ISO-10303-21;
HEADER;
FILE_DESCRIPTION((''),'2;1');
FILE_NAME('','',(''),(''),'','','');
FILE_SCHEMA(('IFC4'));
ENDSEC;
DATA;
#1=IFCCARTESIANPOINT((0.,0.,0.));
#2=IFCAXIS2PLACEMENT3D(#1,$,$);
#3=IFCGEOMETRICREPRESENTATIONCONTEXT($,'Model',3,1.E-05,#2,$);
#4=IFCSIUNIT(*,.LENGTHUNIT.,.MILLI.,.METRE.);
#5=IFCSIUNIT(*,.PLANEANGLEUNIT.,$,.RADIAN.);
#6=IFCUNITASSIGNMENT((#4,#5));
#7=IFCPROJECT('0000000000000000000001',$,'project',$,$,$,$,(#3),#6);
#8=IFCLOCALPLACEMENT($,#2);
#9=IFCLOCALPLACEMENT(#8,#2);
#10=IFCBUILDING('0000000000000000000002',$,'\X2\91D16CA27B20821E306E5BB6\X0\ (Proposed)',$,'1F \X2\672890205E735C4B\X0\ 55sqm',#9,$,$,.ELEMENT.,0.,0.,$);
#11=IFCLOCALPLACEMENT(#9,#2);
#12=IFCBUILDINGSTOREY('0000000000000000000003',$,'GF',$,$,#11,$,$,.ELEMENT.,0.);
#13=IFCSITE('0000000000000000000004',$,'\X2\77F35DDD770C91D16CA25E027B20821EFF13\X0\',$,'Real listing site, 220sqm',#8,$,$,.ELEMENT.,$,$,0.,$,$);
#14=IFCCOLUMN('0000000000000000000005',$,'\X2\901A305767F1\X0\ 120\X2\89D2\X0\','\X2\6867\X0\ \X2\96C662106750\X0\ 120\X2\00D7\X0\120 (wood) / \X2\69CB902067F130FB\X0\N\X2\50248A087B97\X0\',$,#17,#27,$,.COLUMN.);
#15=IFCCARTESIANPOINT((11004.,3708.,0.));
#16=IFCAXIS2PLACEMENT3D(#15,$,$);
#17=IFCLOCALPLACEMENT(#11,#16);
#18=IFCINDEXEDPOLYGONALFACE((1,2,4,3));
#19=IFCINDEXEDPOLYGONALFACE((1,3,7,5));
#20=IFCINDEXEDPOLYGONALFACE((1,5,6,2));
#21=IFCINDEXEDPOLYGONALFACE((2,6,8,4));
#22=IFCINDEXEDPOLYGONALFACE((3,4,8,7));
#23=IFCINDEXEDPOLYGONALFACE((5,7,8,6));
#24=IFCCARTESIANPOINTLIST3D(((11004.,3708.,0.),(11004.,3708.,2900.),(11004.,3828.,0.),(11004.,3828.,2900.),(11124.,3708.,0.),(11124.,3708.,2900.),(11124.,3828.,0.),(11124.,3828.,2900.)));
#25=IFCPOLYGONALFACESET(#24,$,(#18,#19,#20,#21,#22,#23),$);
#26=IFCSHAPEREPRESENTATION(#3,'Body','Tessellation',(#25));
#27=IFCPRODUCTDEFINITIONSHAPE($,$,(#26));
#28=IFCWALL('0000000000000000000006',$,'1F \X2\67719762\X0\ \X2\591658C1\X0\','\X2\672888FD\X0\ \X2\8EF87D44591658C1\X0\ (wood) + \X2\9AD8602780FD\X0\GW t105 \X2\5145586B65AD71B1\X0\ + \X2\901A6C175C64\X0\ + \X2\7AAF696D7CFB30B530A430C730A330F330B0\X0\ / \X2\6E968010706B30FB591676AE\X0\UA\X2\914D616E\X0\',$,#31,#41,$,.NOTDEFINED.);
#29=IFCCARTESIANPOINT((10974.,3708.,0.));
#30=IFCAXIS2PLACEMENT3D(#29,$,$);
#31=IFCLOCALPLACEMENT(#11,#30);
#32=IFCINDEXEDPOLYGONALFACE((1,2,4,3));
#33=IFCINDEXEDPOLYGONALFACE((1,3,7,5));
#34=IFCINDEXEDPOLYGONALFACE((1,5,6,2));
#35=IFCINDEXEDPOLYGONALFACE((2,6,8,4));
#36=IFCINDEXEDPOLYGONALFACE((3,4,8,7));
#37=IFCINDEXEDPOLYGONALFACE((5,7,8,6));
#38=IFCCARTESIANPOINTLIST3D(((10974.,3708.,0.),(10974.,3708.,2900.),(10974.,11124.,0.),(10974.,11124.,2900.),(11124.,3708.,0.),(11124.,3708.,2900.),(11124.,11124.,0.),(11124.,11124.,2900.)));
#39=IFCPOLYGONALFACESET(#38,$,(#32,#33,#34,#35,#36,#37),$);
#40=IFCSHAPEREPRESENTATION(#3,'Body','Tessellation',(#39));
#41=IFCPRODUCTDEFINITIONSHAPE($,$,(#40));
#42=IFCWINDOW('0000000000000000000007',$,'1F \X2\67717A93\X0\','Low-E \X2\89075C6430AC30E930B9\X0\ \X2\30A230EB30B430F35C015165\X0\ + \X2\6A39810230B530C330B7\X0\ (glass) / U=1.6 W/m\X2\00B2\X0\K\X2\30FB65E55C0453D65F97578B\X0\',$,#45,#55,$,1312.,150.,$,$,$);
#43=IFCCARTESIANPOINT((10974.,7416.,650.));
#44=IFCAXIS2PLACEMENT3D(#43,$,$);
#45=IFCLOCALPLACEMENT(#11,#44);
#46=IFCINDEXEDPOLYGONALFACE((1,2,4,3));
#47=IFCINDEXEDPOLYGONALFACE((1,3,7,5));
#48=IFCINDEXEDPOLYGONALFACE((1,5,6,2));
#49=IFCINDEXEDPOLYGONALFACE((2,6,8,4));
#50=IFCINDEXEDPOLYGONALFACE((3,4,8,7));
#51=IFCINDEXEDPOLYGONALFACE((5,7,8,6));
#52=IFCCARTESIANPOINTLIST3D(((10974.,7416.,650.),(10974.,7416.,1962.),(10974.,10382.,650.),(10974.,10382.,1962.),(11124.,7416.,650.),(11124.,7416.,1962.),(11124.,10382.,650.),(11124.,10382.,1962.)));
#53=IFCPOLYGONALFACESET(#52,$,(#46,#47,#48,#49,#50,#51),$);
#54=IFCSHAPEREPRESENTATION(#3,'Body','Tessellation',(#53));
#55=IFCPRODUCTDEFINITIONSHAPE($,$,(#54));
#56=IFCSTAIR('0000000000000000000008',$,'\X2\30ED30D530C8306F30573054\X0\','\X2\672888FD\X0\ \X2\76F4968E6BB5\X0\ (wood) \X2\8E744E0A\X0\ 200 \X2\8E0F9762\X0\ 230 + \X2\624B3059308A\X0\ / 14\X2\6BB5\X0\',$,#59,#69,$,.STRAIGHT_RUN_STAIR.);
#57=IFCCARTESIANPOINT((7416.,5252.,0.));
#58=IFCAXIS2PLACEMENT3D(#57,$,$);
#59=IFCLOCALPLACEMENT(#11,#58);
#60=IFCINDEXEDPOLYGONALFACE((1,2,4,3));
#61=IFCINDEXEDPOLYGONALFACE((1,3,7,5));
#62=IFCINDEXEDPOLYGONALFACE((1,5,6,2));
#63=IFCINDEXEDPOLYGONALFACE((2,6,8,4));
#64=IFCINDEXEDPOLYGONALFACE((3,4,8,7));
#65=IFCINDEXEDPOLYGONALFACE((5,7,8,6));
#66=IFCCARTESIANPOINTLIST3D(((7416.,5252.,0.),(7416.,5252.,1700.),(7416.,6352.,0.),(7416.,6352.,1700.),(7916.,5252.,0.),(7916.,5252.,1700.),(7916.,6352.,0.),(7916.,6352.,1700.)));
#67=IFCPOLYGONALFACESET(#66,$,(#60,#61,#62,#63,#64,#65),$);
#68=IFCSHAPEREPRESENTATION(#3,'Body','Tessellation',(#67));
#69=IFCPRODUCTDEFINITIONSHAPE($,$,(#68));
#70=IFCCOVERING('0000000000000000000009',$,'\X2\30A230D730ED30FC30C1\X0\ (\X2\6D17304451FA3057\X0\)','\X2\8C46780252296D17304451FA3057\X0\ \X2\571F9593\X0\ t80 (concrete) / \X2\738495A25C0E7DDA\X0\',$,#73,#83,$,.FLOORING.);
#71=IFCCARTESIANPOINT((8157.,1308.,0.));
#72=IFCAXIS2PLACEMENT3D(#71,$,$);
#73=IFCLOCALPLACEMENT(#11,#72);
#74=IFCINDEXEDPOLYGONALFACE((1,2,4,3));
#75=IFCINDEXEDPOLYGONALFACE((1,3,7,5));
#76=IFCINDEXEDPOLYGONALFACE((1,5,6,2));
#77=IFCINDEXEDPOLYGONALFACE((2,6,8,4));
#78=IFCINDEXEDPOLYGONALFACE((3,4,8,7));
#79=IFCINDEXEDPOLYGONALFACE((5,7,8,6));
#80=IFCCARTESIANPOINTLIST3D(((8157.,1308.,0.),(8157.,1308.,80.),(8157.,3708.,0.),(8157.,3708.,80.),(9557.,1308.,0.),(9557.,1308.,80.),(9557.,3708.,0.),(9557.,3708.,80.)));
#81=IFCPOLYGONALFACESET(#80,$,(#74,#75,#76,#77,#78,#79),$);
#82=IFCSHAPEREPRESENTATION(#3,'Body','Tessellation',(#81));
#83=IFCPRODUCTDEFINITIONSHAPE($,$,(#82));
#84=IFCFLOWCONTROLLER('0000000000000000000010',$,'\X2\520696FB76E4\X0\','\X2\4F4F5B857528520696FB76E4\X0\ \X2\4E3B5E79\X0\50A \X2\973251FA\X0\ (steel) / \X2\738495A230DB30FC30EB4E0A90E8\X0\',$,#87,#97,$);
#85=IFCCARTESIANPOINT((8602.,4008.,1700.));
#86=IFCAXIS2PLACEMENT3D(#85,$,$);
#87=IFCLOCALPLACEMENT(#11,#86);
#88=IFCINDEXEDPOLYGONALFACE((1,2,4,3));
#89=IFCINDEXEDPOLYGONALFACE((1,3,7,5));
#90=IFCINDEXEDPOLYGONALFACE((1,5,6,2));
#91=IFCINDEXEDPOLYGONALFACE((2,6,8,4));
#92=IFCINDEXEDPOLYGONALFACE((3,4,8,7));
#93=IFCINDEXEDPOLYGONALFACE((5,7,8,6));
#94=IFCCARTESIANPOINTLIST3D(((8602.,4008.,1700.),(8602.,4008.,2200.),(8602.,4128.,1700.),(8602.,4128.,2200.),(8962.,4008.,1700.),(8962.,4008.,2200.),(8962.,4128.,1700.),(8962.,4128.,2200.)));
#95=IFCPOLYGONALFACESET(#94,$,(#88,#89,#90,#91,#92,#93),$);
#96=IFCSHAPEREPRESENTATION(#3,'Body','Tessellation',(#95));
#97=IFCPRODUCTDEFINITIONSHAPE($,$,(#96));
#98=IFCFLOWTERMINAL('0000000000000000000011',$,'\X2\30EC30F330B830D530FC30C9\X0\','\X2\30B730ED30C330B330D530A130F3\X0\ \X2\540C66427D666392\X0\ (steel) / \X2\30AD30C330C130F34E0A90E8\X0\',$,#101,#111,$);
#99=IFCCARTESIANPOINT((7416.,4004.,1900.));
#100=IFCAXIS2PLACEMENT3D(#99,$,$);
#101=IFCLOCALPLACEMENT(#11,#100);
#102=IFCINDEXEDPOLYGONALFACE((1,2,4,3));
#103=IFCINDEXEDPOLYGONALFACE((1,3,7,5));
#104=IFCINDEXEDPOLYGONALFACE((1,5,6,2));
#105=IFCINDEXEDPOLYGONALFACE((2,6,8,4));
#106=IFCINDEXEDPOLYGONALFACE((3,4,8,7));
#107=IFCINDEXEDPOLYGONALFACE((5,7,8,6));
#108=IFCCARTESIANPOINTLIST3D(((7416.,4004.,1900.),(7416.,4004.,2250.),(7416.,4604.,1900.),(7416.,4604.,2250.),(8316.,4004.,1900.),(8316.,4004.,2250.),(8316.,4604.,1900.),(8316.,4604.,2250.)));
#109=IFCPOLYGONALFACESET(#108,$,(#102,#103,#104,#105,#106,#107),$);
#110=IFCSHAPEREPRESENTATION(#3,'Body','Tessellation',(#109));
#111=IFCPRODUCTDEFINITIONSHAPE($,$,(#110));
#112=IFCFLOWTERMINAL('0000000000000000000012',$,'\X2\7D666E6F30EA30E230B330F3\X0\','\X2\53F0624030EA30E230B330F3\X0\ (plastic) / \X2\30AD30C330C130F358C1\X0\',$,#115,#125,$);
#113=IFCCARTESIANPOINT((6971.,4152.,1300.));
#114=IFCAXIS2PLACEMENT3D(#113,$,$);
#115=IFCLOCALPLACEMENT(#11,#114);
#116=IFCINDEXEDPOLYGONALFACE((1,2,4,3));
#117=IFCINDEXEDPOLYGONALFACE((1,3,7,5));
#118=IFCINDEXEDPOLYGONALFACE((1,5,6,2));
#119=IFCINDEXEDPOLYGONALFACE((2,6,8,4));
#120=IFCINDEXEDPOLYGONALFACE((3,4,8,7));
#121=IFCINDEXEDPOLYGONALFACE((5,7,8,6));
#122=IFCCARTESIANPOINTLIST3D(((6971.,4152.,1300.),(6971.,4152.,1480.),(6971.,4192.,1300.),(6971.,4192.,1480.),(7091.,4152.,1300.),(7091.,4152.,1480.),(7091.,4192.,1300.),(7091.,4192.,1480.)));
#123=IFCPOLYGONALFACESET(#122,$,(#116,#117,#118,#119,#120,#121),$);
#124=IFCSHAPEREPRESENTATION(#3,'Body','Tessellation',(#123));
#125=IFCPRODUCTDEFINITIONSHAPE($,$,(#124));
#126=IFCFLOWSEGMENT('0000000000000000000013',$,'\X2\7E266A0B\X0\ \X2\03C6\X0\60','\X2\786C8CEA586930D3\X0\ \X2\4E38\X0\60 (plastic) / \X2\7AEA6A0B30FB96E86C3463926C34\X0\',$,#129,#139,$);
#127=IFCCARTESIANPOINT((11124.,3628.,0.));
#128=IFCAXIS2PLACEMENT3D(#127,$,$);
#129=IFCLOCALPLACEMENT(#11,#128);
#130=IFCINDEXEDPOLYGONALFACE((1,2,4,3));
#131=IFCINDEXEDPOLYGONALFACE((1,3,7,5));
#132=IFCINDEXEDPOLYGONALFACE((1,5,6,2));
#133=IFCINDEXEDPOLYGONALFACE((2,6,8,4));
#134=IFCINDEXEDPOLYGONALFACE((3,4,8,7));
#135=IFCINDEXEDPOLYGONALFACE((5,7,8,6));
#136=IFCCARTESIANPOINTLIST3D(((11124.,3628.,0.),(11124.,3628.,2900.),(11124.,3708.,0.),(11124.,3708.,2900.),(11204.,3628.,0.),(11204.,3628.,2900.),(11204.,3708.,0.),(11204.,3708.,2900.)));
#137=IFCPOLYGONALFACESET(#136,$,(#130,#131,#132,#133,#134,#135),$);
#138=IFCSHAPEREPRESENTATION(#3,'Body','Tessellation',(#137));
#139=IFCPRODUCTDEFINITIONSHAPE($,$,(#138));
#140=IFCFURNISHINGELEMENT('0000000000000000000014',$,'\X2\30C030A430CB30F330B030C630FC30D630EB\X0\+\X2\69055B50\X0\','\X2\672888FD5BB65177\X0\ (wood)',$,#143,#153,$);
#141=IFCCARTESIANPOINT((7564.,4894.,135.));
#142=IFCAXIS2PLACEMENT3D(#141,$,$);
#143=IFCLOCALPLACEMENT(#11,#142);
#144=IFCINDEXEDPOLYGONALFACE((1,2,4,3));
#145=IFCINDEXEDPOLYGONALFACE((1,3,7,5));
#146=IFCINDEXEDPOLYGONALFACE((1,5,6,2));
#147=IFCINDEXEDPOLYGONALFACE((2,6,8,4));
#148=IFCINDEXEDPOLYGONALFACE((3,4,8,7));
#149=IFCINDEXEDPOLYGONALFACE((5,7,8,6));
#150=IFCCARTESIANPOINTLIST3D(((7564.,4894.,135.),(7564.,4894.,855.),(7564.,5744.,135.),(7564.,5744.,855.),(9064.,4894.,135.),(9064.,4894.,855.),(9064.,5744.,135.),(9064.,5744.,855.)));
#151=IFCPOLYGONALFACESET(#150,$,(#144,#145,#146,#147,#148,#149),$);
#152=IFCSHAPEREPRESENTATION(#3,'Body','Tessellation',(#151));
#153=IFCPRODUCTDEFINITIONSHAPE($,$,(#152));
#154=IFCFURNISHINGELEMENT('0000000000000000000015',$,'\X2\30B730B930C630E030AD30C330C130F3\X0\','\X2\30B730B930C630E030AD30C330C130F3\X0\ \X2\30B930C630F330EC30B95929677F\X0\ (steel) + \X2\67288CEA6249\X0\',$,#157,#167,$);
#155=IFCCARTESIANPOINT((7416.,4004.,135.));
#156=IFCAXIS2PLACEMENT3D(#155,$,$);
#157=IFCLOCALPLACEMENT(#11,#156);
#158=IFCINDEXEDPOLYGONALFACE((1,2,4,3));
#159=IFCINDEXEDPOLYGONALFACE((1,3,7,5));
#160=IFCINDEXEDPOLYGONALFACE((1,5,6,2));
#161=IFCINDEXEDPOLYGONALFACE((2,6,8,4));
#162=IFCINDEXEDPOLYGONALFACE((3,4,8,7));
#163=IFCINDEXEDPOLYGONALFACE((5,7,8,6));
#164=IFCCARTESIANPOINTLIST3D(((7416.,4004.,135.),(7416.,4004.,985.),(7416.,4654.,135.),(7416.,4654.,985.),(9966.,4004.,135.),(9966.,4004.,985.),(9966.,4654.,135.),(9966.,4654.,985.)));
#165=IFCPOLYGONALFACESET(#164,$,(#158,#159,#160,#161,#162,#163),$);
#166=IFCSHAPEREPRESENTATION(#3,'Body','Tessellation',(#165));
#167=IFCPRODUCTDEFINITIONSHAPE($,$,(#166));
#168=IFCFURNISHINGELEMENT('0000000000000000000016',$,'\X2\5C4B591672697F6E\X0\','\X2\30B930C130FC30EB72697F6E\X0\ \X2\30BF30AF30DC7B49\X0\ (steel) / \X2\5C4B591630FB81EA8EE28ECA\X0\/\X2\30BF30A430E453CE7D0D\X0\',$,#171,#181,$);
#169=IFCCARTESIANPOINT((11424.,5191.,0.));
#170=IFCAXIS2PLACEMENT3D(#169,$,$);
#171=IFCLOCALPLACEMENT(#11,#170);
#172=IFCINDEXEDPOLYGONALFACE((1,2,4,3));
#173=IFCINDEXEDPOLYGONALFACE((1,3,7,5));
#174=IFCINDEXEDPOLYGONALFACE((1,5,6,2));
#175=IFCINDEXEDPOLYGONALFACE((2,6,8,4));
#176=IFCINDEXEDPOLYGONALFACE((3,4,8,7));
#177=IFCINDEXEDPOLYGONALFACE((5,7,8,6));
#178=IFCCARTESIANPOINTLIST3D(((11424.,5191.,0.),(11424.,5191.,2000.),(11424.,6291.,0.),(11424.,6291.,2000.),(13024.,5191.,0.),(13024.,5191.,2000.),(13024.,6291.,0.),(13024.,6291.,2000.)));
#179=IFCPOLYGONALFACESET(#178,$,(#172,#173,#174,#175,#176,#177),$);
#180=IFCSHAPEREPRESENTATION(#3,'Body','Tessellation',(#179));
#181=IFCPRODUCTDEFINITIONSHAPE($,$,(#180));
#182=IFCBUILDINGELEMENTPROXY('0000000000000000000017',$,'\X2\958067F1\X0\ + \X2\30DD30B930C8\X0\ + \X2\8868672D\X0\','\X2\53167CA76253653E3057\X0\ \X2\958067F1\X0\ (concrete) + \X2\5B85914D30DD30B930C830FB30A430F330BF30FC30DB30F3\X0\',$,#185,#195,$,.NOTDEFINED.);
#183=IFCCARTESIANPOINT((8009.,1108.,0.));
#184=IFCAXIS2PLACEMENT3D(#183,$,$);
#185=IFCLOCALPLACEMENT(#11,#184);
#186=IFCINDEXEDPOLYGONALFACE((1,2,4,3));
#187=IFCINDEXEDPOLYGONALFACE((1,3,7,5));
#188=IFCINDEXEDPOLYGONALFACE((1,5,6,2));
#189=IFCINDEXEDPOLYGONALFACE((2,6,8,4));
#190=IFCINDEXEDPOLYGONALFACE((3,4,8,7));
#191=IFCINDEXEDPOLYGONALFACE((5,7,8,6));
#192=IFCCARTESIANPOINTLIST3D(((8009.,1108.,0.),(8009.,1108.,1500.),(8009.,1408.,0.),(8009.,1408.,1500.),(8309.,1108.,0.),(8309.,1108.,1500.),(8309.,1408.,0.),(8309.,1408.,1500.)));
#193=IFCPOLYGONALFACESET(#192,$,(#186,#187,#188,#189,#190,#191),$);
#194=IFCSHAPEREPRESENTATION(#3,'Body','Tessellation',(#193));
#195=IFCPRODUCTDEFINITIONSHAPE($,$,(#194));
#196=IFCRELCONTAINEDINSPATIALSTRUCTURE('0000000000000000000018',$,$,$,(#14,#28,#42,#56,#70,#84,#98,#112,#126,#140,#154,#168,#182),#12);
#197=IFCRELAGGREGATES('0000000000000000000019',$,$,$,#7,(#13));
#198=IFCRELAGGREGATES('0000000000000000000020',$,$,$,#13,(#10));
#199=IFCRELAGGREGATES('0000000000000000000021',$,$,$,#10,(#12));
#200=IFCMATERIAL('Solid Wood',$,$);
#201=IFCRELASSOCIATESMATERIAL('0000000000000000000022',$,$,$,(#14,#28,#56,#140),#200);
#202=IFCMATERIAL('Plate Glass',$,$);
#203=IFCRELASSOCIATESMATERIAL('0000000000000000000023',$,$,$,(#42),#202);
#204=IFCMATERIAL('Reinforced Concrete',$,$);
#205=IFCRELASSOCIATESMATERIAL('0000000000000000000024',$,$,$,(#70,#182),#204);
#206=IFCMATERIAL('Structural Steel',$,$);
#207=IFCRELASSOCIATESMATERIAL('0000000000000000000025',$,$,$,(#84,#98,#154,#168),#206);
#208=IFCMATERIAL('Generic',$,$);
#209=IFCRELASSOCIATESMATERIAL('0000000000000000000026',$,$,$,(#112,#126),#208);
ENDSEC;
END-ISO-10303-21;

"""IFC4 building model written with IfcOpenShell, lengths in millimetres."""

from ifc_helpers import new_model, si_unit, frame, frame_2d, origin, place, context, project, spatial, rectangle, extrude, material, element, fill, save


model = new_model("IFC4")

# Units and contexts
model_context = context("Model", 3, precision=1e-05, world=origin())
ifc_project = project(units=[si_unit("LENGTHUNIT", "METRE", prefix="MILLI"), si_unit("PLANEANGLEUNIT", "RADIAN")], contexts=[model_context])

# Site, building, storey
site_placement = place(None, origin())
site = spatial("IfcSite", under=ifc_project, at=site_placement, Name="石川県金沢市笠舞３", ObjectType="Real listing site, 220sqm", CompositionType="ELEMENT", RefElevation=0.0)
building_placement = place(site_placement, origin())
building = spatial("IfcBuilding", under=site, at=building_placement, Name="金沢笠舞の家 (Proposed)", ObjectType="1F 木造平屋 55sqm", CompositionType="ELEMENT", ElevationOfRefHeight=0.0, ElevationOfTerrain=0.0)
storey_placement = place(building_placement, origin())
storey = spatial("IfcBuildingStorey", under=building, at=storey_placement, Name="GF", CompositionType="ELEMENT", Elevation=0.0)

# Column
ifc_material_1 = material(Name="Solid Wood")
column_1_placement = place(storey_placement, frame((11004.0, 3708.0, 0.0)))
element("IfcColumn", 1, at=column_1_placement, inside=storey, material=ifc_material_1, Name="通し柱 120角", Description="桧 集成材 120×120 (wood) / 構造柱・N値計算", PredefinedType="COLUMN", context=model_context, shape_type="SweptSolid", body=[
    extrude(rectangle(XDim=120.0, YDim=120.0, at=frame_2d((60.0, 60.0))), frame((11004.0, 3708.0, 0.0)), (0.0, 0.0, 1.0), 2900.0),
])

# Wall, opening, window
wall_1_placement = place(storey_placement, frame((10974.0, 3708.0, 0.0)))
wall_1 = element("IfcWall", 2, at=wall_1_placement, inside=storey, material=ifc_material_1, Name="1F 東面 外壁", Description="木製 軸組外壁 (wood) + 高性能GW t105 充填断熱 + 通気層 + 窯業系サイディング / 準耐火・外皮UA配慮", PredefinedType="NOTDEFINED", context=model_context, shape_type="SweptSolid", body=[
    extrude(rectangle(XDim=150.0, YDim=7416.0, at=frame_2d((75.0, 3708.0))), frame((10974.0, 3708.0, 0.0)), (0.0, 0.0, 1.0), 2900.0),
])
opening_placement = place(storey_placement, frame((10974.0, 7416.0, 650.0)))
opening = element("IfcOpeningElement", 3, at=opening_placement, cuts=wall_1, PredefinedType="NOTDEFINED", context=model_context, shape_type="SweptSolid", body=[
    extrude(rectangle(XDim=150.0, YDim=2966.0, at=frame_2d((75.0, 1483.0))), frame((10974.0, 7416.0, 650.0)), (0.0, 0.0, 1.0), 1312.0),
])
ifc_material_2 = material(Name="Plate Glass")
window_placement = place(storey_placement, frame((10974.0, 7416.0, 650.0)))
window = element("IfcWindow", 4, at=window_placement, inside=storey, material=ifc_material_2, Name="1F 東窓", Description="Low-E 複層ガラス アルゴン封入 + 樹脂サッシ (glass) / U=1.6 W/m²K・日射取得型", OverallHeight=1312.0, OverallWidth=150.0, context=model_context, shape_type="SweptSolid", body=[
    extrude(rectangle(XDim=150.0, YDim=2966.0, at=frame_2d((75.0, 1483.0))), frame((10974.0, 7416.0, 650.0)), (0.0, 0.0, 1.0), 1312.0),
])
fill(opening, window)

# Stair
stair_placement = place(storey_placement, frame((7416.0, 5252.0, 0.0)))
element("IfcStair", 5, at=stair_placement, inside=storey, material=ifc_material_1, Name="ロフトはしご", Description="木製 直階段 (wood) 蹴上 200 踏面 230 + 手すり / 14段", PredefinedType="STRAIGHT_RUN_STAIR", context=model_context, shape_type="SweptSolid", body=[
    extrude(rectangle(XDim=500.0, YDim=1100.0, at=frame_2d((250.0, 550.0))), frame((7416.0, 5252.0, 0.0)), (0.0, 0.0, 1.0), 1700.0),
])

# Covering
ifc_material_3 = material(Name="Reinforced Concrete")
covering_placement = place(storey_placement, frame((8157.0, 1308.0, 0.0)))
element("IfcCovering", 6, at=covering_placement, inside=storey, material=ifc_material_3, Name="アプローチ (洗い出し)", Description="豆砂利洗い出し 土間 t80 (concrete) / 玄関導線", PredefinedType="FLOORING", context=model_context, shape_type="SweptSolid", body=[
    extrude(rectangle(XDim=1400.0, YDim=2400.0, at=frame_2d((700.0, 1200.0))), frame((8157.0, 1308.0, 0.0)), (0.0, 0.0, 1.0), 80.0),
])

# Flow controller
ifc_material_4 = material(Name="Structural Steel")
flow_controller_placement = place(storey_placement, frame((8602.0, 4008.0, 1700.0)))
element("IfcFlowController", 7, at=flow_controller_placement, inside=storey, material=ifc_material_4, Name="分電盤", Description="住宅用分電盤 主幹50A 露出 (steel) / 玄関ホール上部", context=model_context, shape_type="SweptSolid", body=[
    extrude(rectangle(XDim=360.0, YDim=120.0, at=frame_2d((180.0, 60.0))), frame((8602.0, 4008.0, 1700.0)), (0.0, 0.0, 1.0), 500.0),
])

# Flow terminals
flow_terminal_1_placement = place(storey_placement, frame((7416.0, 4004.0, 1900.0)))
element("IfcFlowTerminal", 8, at=flow_terminal_1_placement, inside=storey, material=ifc_material_4, Name="レンジフード", Description="シロッコファン 同時給排 (steel) / キッチン上部", context=model_context, shape_type="SweptSolid", body=[
    extrude(rectangle(XDim=900.0, YDim=600.0, at=frame_2d((450.0, 300.0))), frame((7416.0, 4004.0, 1900.0)), (0.0, 0.0, 1.0), 350.0),
])
ifc_material_5 = material(Name="Generic")
flow_terminal_2_placement = place(storey_placement, frame((6971.0, 4152.0, 1300.0)))
element("IfcFlowTerminal", 9, at=flow_terminal_2_placement, inside=storey, material=ifc_material_5, Name="給湯リモコン", Description="台所リモコン (plastic) / キッチン壁", context=model_context, shape_type="SweptSolid", body=[
    extrude(rectangle(XDim=120.0, YDim=40.0, at=frame_2d((60.0, 20.0))), frame((6971.0, 4152.0, 1300.0)), (0.0, 0.0, 1.0), 180.0),
])

# Flow segment
flow_segment_placement = place(storey_placement, frame((11124.0, 3628.0, 0.0)))
element("IfcFlowSegment", 10, at=flow_segment_placement, inside=storey, material=ifc_material_5, Name="縦樋 φ60", Description="硬質塩ビ 丸60 (plastic) / 竪樋・雨水排水", context=model_context, shape_type="SweptSolid", body=[
    extrude(rectangle(XDim=80.0, YDim=80.0, at=frame_2d((40.0, 40.0))), frame((11124.0, 3628.0, 0.0)), (0.0, 0.0, 1.0), 2900.0),
])

# Furnishing elements
furnishing_1_placement = place(storey_placement, frame((7564.0, 4894.0, 135.0)))
element("IfcFurnishingElement", 11, at=furnishing_1_placement, inside=storey, material=ifc_material_1, Name="ダイニングテーブル+椅子", Description="木製家具 (wood)", context=model_context, shape_type="SweptSolid", body=[
    extrude(rectangle(XDim=1500.0, YDim=850.0, at=frame_2d((750.0, 425.0))), frame((7564.0, 4894.0, 135.0)), (0.0, 0.0, 1.0), 720.0),
])
furnishing_2_placement = place(storey_placement, frame((7416.0, 4004.0, 135.0)))
element("IfcFurnishingElement", 12, at=furnishing_2_placement, inside=storey, material=ifc_material_4, Name="システムキッチン", Description="システムキッチン ステンレス天板 (steel) + 木質扉", context=model_context, shape_type="SweptSolid", body=[
    extrude(rectangle(XDim=2550.0, YDim=650.0, at=frame_2d((1275.0, 325.0))), frame((7416.0, 4004.0, 135.0)), (0.0, 0.0, 1.0), 850.0),
])
furnishing_3_placement = place(storey_placement, frame((11424.0, 5191.0, 0.0)))
element("IfcFurnishingElement", 13, at=furnishing_3_placement, inside=storey, material=ifc_material_4, Name="屋外物置", Description="スチール物置 タクボ等 (steel) / 屋外・自転車/タイヤ収納", context=model_context, shape_type="SweptSolid", body=[
    extrude(rectangle(XDim=1600.0, YDim=1100.0, at=frame_2d((800.0, 550.0))), frame((11424.0, 5191.0, 0.0)), (0.0, 0.0, 1.0), 2000.0),
])

# Building element proxy
proxy_placement = place(storey_placement, frame((8009.0, 1108.0, 0.0)))
element("IfcBuildingElementProxy", 14, at=proxy_placement, inside=storey, material=ifc_material_3, Name="門柱 + ポスト + 表札", Description="化粧打放し 門柱 (concrete) + 宅配ポスト・インターホン", PredefinedType="NOTDEFINED", context=model_context, shape_type="SweptSolid", body=[
    extrude(rectangle(XDim=300.0, YDim=300.0, at=frame_2d((150.0, 150.0))), frame((8009.0, 1108.0, 0.0)), (0.0, 0.0, 1.0), 1500.0),
])

save(model, "model.ifc")
